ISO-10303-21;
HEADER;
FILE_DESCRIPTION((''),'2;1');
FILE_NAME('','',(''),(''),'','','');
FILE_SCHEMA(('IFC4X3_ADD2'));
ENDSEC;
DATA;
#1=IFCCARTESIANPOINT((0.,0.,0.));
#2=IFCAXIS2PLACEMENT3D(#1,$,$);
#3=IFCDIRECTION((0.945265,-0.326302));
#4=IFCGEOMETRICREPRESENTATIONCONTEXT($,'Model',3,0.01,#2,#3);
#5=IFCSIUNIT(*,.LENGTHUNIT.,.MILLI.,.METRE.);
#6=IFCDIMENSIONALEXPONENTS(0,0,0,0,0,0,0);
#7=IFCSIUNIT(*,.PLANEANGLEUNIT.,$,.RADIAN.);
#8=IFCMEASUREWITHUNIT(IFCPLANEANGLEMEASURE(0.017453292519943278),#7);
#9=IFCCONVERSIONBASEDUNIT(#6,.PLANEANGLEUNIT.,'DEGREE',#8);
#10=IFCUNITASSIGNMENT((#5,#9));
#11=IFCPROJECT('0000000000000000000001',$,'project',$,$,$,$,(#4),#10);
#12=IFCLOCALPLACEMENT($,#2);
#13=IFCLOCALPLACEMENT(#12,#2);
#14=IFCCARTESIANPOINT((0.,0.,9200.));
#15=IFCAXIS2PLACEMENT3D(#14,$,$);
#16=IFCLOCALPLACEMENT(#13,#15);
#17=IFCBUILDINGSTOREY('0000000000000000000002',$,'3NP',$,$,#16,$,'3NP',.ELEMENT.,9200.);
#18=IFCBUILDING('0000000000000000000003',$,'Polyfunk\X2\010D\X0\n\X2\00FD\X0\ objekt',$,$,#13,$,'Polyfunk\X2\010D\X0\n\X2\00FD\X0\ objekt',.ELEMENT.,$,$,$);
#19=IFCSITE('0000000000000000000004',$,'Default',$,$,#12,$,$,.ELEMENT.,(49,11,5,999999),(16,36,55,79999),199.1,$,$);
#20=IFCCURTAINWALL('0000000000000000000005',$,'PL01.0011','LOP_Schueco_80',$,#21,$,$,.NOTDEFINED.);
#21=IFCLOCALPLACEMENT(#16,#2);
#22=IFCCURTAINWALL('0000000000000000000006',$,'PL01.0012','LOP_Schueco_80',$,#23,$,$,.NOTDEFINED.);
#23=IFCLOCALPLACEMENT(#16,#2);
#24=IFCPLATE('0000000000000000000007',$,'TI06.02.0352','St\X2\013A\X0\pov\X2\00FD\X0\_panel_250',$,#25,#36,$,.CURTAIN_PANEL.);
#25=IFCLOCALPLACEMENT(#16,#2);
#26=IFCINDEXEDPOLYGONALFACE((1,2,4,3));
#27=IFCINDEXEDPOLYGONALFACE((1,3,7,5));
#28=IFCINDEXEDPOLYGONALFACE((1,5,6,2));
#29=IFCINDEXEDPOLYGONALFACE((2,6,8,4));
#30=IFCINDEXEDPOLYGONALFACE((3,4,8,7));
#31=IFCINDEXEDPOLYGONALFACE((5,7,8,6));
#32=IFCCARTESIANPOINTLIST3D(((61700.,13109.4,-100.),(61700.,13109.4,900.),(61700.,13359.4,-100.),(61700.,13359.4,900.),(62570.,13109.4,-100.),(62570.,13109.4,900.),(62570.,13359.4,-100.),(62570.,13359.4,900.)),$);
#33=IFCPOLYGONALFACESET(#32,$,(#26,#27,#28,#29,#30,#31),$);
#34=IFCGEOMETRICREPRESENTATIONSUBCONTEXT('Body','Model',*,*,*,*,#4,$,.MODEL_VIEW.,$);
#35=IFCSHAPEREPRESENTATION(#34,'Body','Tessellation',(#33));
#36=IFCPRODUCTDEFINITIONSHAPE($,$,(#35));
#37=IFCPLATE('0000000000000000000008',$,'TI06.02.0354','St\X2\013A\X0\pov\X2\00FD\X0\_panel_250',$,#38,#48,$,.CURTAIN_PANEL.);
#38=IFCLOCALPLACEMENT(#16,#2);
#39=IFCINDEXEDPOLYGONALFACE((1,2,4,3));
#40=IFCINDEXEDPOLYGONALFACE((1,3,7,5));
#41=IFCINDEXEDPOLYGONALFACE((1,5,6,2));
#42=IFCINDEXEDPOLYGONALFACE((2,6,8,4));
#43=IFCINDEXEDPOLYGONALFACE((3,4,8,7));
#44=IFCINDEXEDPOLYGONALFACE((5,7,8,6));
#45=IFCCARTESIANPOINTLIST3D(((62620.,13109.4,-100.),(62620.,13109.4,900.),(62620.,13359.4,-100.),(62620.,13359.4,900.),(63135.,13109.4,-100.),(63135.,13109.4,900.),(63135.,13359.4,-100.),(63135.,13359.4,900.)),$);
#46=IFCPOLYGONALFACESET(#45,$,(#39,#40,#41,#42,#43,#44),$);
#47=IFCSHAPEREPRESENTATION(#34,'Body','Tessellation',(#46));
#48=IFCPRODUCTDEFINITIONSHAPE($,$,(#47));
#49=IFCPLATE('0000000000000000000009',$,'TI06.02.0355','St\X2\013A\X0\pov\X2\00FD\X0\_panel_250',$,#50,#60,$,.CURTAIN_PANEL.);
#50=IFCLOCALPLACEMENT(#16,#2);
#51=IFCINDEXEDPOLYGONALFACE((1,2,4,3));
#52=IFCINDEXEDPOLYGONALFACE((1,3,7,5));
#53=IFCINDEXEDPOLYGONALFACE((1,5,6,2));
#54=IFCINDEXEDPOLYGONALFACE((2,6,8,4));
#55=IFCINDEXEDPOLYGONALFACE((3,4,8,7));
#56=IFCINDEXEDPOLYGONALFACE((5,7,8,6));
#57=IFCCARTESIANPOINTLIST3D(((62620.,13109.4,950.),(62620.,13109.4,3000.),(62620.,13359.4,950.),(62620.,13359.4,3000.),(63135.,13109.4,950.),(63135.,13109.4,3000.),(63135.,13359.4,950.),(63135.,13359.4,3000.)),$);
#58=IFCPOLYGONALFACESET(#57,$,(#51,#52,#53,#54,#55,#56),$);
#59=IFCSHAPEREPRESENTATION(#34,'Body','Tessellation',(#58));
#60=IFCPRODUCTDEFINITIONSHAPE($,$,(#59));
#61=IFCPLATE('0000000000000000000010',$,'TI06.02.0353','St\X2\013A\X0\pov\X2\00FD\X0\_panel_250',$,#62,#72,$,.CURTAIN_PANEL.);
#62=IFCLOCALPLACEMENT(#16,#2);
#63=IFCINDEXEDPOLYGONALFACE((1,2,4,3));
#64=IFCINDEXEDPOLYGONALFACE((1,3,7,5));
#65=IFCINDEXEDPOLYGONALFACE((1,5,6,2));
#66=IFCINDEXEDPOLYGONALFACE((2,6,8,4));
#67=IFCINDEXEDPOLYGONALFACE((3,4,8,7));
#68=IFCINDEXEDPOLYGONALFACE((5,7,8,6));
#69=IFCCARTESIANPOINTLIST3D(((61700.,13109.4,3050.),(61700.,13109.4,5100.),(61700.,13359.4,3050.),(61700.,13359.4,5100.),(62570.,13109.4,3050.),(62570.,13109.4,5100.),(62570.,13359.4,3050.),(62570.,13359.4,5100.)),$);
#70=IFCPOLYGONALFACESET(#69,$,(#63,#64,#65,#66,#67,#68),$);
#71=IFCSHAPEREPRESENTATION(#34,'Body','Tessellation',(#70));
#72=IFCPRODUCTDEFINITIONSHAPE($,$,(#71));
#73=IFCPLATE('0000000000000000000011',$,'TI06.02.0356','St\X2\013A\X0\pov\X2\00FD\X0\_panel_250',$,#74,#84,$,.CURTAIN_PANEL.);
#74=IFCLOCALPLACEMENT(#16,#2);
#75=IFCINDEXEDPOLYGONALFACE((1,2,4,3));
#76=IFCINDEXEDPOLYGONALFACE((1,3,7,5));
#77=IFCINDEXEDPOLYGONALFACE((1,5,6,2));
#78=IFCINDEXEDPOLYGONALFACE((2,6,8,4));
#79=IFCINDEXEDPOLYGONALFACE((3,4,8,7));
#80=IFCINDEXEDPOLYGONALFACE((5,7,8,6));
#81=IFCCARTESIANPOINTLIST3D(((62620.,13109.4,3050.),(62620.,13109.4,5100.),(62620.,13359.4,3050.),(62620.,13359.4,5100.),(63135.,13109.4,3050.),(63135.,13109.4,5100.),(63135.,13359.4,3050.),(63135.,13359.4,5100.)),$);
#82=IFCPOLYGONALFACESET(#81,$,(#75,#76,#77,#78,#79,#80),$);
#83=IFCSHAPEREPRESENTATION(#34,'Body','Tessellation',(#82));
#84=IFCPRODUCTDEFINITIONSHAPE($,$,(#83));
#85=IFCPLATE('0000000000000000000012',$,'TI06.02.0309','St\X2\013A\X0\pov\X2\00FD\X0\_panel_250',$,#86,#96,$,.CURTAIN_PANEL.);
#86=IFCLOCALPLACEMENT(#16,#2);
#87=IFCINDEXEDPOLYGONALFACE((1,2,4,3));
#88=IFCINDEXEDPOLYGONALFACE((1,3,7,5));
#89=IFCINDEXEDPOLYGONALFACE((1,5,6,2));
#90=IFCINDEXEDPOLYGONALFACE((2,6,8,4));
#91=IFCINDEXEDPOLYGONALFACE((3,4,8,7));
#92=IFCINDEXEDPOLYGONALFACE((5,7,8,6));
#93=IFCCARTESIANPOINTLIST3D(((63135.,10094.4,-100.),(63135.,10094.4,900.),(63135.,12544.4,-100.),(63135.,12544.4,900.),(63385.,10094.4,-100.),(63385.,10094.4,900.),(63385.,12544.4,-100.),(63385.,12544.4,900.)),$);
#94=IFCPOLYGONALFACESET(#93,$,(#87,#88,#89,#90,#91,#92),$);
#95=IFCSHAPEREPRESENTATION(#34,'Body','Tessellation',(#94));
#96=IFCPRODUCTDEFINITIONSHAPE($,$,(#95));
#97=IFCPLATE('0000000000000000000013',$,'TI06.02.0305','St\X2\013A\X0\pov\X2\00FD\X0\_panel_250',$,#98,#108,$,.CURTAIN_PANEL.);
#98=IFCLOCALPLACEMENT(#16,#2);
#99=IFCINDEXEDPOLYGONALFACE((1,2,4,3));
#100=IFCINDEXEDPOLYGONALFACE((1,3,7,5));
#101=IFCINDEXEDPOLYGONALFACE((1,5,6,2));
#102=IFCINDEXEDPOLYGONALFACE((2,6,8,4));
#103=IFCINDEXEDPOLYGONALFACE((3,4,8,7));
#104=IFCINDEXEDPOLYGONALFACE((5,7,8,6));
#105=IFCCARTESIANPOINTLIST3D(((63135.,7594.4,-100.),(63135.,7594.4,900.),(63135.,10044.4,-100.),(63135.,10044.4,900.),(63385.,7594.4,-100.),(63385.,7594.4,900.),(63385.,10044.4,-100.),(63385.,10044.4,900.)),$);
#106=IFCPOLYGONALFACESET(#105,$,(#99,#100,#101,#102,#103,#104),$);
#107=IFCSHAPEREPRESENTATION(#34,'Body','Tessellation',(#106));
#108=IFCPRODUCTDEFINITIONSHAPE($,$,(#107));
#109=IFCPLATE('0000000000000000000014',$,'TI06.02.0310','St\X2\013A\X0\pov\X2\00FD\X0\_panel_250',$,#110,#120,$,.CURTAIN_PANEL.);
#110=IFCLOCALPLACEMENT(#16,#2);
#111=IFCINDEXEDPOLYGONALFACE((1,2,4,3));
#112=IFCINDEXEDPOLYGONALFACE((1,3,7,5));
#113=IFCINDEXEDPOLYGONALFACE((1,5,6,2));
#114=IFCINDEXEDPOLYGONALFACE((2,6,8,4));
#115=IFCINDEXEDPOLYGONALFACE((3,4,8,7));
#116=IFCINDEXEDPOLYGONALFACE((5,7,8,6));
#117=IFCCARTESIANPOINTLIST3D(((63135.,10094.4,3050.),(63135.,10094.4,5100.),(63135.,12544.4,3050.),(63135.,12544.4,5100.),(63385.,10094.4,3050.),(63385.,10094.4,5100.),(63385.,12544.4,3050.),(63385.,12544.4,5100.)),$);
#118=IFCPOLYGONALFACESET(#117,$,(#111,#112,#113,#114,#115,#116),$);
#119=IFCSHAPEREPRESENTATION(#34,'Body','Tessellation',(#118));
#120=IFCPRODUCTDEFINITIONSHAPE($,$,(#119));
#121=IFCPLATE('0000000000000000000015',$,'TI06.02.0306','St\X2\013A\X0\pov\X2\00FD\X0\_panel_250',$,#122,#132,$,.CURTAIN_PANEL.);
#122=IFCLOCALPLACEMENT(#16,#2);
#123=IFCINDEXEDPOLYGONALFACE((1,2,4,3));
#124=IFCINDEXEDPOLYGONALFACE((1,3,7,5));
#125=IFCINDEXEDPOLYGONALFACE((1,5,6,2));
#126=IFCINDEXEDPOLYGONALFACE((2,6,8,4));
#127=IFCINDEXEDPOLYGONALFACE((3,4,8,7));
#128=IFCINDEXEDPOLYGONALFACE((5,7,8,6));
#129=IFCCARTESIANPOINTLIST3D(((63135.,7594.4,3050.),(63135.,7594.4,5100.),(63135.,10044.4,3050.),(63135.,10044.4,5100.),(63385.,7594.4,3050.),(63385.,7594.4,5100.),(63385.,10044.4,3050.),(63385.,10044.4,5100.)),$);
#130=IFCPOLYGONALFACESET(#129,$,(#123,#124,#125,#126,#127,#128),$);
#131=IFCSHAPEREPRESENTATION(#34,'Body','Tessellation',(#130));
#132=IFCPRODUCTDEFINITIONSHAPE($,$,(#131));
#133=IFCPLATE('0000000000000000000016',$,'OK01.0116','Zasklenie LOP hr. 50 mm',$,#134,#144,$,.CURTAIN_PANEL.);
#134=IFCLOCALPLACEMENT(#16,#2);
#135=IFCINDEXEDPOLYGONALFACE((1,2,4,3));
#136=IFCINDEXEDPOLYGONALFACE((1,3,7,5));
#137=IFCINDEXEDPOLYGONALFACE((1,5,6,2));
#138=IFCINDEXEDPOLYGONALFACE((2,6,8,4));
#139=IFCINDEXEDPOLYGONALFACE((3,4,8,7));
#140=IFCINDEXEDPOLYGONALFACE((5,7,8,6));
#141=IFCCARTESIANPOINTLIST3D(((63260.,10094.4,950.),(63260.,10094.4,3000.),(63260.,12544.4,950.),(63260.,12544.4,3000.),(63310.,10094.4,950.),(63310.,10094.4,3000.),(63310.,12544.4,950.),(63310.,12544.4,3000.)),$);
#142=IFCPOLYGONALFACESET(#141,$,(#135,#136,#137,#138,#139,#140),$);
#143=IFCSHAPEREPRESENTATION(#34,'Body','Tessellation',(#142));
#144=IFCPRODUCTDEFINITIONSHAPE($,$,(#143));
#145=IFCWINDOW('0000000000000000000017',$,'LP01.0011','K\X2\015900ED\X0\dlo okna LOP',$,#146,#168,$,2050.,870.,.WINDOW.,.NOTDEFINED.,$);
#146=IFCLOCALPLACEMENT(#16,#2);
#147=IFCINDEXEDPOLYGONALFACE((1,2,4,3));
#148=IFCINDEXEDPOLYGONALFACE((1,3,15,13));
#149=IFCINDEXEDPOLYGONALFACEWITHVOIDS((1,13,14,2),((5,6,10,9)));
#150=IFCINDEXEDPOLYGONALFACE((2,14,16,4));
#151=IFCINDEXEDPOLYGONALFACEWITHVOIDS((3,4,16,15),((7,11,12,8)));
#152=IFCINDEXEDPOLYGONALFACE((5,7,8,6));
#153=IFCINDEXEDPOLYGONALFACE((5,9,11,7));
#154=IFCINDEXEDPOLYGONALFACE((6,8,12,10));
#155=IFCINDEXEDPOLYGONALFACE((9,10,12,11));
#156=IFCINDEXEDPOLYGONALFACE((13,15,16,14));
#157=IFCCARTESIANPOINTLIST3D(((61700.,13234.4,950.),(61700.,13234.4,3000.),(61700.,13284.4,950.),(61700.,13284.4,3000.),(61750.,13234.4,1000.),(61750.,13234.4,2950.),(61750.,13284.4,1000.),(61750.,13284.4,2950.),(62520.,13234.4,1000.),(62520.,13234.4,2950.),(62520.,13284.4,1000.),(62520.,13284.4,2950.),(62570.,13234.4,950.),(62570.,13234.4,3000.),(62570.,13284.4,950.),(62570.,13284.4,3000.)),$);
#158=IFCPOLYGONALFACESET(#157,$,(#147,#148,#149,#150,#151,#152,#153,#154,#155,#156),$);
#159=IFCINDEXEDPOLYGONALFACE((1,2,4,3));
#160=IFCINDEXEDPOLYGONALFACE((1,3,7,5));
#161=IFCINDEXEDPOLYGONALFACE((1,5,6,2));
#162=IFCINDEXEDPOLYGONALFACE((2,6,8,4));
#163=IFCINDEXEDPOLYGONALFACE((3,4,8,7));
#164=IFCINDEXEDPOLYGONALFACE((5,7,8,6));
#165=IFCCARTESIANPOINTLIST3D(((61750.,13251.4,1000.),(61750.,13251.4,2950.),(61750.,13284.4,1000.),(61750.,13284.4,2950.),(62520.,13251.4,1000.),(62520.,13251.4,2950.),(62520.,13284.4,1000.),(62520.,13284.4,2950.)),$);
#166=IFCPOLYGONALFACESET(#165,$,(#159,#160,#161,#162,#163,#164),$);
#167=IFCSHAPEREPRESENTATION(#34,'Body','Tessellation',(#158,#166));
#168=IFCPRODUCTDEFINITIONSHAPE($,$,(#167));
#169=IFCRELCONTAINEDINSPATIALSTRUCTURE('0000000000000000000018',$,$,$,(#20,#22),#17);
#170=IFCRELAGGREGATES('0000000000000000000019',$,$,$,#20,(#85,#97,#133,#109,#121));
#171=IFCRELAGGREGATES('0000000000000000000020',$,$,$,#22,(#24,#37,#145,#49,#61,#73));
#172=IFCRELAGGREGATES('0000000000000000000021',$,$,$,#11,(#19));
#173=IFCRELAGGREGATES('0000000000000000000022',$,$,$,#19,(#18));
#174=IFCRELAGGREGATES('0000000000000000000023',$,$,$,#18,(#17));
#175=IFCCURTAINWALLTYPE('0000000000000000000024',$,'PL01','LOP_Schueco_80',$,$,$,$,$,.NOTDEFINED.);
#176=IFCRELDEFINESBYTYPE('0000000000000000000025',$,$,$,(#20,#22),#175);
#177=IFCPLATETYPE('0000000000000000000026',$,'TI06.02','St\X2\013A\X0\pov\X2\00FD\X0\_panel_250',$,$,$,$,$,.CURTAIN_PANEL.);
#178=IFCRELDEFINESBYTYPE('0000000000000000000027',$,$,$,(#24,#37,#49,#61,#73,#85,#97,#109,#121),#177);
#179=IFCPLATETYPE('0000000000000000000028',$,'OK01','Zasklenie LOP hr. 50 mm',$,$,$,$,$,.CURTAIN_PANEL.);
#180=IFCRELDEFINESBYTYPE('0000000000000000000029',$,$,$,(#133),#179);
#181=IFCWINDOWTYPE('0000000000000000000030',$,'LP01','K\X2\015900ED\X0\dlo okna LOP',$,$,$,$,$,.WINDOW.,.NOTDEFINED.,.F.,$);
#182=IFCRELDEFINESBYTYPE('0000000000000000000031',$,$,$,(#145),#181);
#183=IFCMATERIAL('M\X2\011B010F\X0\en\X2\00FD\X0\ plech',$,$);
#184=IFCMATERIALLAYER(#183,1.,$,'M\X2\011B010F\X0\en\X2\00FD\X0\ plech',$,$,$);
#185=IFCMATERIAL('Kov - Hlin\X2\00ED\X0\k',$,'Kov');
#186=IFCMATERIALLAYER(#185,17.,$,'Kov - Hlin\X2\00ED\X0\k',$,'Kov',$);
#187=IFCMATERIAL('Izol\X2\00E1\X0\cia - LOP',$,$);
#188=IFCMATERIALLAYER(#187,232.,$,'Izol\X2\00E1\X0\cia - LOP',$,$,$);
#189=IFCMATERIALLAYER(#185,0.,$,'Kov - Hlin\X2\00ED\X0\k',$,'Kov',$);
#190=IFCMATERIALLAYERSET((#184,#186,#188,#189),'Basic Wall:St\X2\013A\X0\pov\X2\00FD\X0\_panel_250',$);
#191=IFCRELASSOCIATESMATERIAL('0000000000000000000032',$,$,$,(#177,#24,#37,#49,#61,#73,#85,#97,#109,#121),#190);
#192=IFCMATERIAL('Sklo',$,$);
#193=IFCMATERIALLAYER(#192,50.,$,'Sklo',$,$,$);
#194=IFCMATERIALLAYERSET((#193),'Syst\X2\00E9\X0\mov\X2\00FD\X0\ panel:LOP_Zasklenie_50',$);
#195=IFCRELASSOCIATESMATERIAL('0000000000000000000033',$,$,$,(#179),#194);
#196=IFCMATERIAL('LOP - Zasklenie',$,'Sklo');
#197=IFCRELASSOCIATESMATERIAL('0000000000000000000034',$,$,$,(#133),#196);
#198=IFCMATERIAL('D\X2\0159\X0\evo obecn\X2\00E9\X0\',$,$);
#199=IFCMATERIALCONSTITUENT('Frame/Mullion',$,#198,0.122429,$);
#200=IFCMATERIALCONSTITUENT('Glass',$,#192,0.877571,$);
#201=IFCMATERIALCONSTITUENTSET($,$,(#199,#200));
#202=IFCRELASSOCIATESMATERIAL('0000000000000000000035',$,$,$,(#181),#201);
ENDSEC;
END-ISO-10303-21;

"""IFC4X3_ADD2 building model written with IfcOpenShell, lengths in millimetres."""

from ifc_helpers import new_model, entity, si_unit, converted_unit, direction, frame, frame_2d, origin, origin_2d_with_axis, place, context, subcontext, project, spatial, polyline, rectangle, outline, extrude, source, transform, mapped, material, layer, layer_set, layer_usage, constituent, constituent_set, type_object, type_shapes, element, aggregate, save


model = new_model("IFC4X3_ADD2")

# Units and contexts
model_context = context("Model", 3, precision=0.01, world=origin(), true_north=direction((0.945265, -0.326302)))
body_context = subcontext(model_context, "Body", "Model", "MODEL_VIEW")
ifc_project = project(units=[si_unit("LENGTHUNIT", "METRE", prefix="MILLI"), converted_unit("PLANEANGLEUNIT", "DEGREE", entity("IfcPlaneAngleMeasure", 0.017453292519943278), si_unit("PLANEANGLEUNIT", "RADIAN"), dimensions=[0, 0, 0, 0, 0, 0, 0])], contexts=[model_context])

# Site, building, storey
site_placement = place(None, origin())
site = spatial("IfcSite", under=ifc_project, at=site_placement, Name="Default", CompositionType="ELEMENT", RefLatitude=(49, 11, 5, 999999), RefLongitude=(16, 36, 55, 79999), RefElevation=199.1)
building_placement = place(site_placement, origin())
building = spatial("IfcBuilding", under=site, at=building_placement, Name="Polyfunkčný objekt", LongName="Polyfunkčný objekt", CompositionType="ELEMENT")
storey_placement = place(building_placement, frame((0.0, 0.0, 9200.0)))
storey = spatial("IfcBuildingStorey", under=building, at=storey_placement, Name="3NP", LongName="3NP", CompositionType="ELEMENT", Elevation=9200.0)

# Curtain walls
curtain_wall_type = type_object("IfcCurtainWallType", Name="PL01", Description="LOP_Schueco_80", PredefinedType="NOTDEFINED")
curtain_wall_1_placement = place(storey_placement, frame((0.0, 0.0, -9200.0)))
curtain_wall_1 = element("IfcCurtainWall", 1, at=curtain_wall_1_placement, inside=storey, type_object=curtain_wall_type, Name="PL01.0011", Description="LOP_Schueco_80", PredefinedType="NOTDEFINED")
curtain_wall_2_placement = place(storey_placement, frame((0.0, 0.0, -9200.0)))
curtain_wall_2 = element("IfcCurtainWall", 2, at=curtain_wall_2_placement, inside=storey, type_object=curtain_wall_type, Name="PL01.0012", Description="LOP_Schueco_80", PredefinedType="NOTDEFINED")

# Plates
ifc_material_1 = material(Name="Měďený plech")
ifc_layer_1 = layer(ifc_material_1, 1.0, Name="Měďený plech")
ifc_material_2 = material(Name="Kov - Hliník", Category="Kov")
ifc_layer_2 = layer(ifc_material_2, 17.0, Name="Kov - Hliník", Category="Kov")
ifc_material_3 = material(Name="Izolácia - LOP")
ifc_layer_3 = layer(ifc_material_3, 232.0, Name="Izolácia - LOP")
ifc_layer_4 = layer(ifc_material_2, 0.0, Name="Kov - Hliník", Category="Kov")
ifc_layer_set_1 = layer_set([ifc_layer_1, ifc_layer_2, ifc_layer_3, ifc_layer_4], Name="Basic Wall:Stĺpový_panel_250")
ifc_layer_usage_1 = layer_usage(ifc_layer_set_1, "AXIS2", "NEGATIVE", 125.0)
plate_type_1 = type_object("IfcPlateType", Name="TI06.02", Description="Stĺpový_panel_250", PredefinedType="CURTAIN_PANEL", material=ifc_layer_set_1)
plate_1_placement = place(storey_placement, frame((61700.0, 13234.4, -100.0)))
plate_1 = element("IfcPlate", 3, at=plate_1_placement, type_object=plate_type_1, material=ifc_layer_usage_1, Name="TI06.02.0352", Description="Stĺpový_panel_250", PredefinedType="CURTAIN_PANEL", context=body_context, shape_type="SweptSolid", body=[
    extrude(rectangle(XDim=250.0, YDim=870.0, at=frame_2d((0.0, 0.0), x_axis=(1.0, 0.0))), frame((435.0, 0.0, 0.0), z_axis=(0.0, 0.0, 1.0), x_axis=(0.0, 1.0, 0.0)), (0.0, 0.0, 1.0), 1000.0),
])
ifc_layer_usage_2 = layer_usage(ifc_layer_set_1, "AXIS2", "NEGATIVE", 125.0)
plate_2_placement = place(storey_placement, frame((62620.0, 13234.4, -100.0)))
plate_2 = element("IfcPlate", 4, at=plate_2_placement, type_object=plate_type_1, material=ifc_layer_usage_2, Name="TI06.02.0354", Description="Stĺpový_panel_250", PredefinedType="CURTAIN_PANEL", context=body_context, shape_type="SweptSolid", body=[
    extrude(rectangle(XDim=250.0, YDim=515.0, at=frame_2d((0.0, 0.0), x_axis=(1.0, 0.0))), frame((257.5, 0.0, 0.0), z_axis=(0.0, 0.0, 1.0), x_axis=(0.0, 1.0, 0.0)), (0.0, 0.0, 1.0), 1000.0),
])
ifc_layer_usage_3 = layer_usage(ifc_layer_set_1, "AXIS2", "NEGATIVE", 125.0)
plate_3_placement = place(storey_placement, frame((62620.0, 13234.4, 950.0)))
plate_3 = element("IfcPlate", 5, at=plate_3_placement, type_object=plate_type_1, material=ifc_layer_usage_3, Name="TI06.02.0355", Description="Stĺpový_panel_250", PredefinedType="CURTAIN_PANEL", context=body_context, shape_type="SweptSolid", body=[
    extrude(rectangle(XDim=250.0, YDim=515.0, at=frame_2d((0.0, 0.0), x_axis=(1.0, 0.0))), frame((257.5, 0.0, 0.0), z_axis=(0.0, 0.0, 1.0), x_axis=(0.0, 1.0, 0.0)), (0.0, 0.0, 1.0), 2050.0),
])
ifc_layer_usage_4 = layer_usage(ifc_layer_set_1, "AXIS2", "NEGATIVE", 125.0)
plate_4_placement = place(storey_placement, frame((61700.0, 13234.4, 3050.0)))
plate_4 = element("IfcPlate", 6, at=plate_4_placement, type_object=plate_type_1, material=ifc_layer_usage_4, Name="TI06.02.0353", Description="Stĺpový_panel_250", PredefinedType="CURTAIN_PANEL", context=body_context, shape_type="SweptSolid", body=[
    extrude(rectangle(XDim=250.0, YDim=870.0, at=frame_2d((0.0, 0.0), x_axis=(1.0, 0.0))), frame((435.0, 0.0, 0.0), z_axis=(0.0, 0.0, 1.0), x_axis=(0.0, 1.0, 0.0)), (0.0, 0.0, 1.0), 2050.0),
])
ifc_layer_usage_5 = layer_usage(ifc_layer_set_1, "AXIS2", "NEGATIVE", 125.0)
plate_5_placement = place(storey_placement, frame((62620.0, 13234.4, 3050.0)))
plate_5 = element("IfcPlate", 7, at=plate_5_placement, type_object=plate_type_1, material=ifc_layer_usage_5, Name="TI06.02.0356", Description="Stĺpový_panel_250", PredefinedType="CURTAIN_PANEL", context=body_context, shape_type="SweptSolid", body=[
    extrude(rectangle(XDim=250.0, YDim=515.0, at=frame_2d((0.0, 0.0), x_axis=(1.0, 0.0))), frame((257.5, 0.0, 0.0), z_axis=(0.0, 0.0, 1.0), x_axis=(0.0, 1.0, 0.0)), (0.0, 0.0, 1.0), 2050.0),
])
ifc_layer_usage_6 = layer_usage(ifc_layer_set_1, "AXIS2", "NEGATIVE", 125.0)
plate_6_placement = place(storey_placement, frame((63260.0, 12544.4, -100.0), z_axis=(0.0, 0.0, 1.0), x_axis=(0.0, -1.0, 0.0)))
plate_6 = element("IfcPlate", 8, at=plate_6_placement, type_object=plate_type_1, material=ifc_layer_usage_6, Name="TI06.02.0309", Description="Stĺpový_panel_250", PredefinedType="CURTAIN_PANEL", context=body_context, shape_type="SweptSolid", body=[
    extrude(rectangle(XDim=250.0, YDim=2450.0, at=frame_2d((0.0, 0.0), x_axis=(1.0, 0.0))), frame((1225.0, 0.0, 0.0), z_axis=(0.0, 0.0, 1.0), x_axis=(0.0, 1.0, 0.0)), (0.0, 0.0, 1.0), 1000.0),
])
ifc_layer_usage_7 = layer_usage(ifc_layer_set_1, "AXIS2", "NEGATIVE", 125.0)
plate_7_placement = place(storey_placement, frame((63260.0, 10044.4, -100.0), z_axis=(0.0, 0.0, 1.0), x_axis=(0.0, -1.0, 0.0)))
plate_7 = element("IfcPlate", 9, at=plate_7_placement, type_object=plate_type_1, material=ifc_layer_usage_7, Name="TI06.02.0305", Description="Stĺpový_panel_250", PredefinedType="CURTAIN_PANEL", context=body_context, shape_type="SweptSolid", body=[
    extrude(rectangle(XDim=250.0, YDim=2450.0, at=origin_2d_with_axis()), frame((1225.0, 0.0, 0.0), z_axis=(0.0, 0.0, 1.0), x_axis=(0.0, 1.0, 0.0)), (0.0, 0.0, 1.0), 1000.0),
])
ifc_layer_usage_8 = layer_usage(ifc_layer_set_1, "AXIS2", "NEGATIVE", 125.0)
plate_8_placement = place(storey_placement, frame((63260.0, 12544.4, 3050.0), z_axis=(0.0, 0.0, 1.0), x_axis=(0.0, -1.0, 0.0)))
plate_8 = element("IfcPlate", 10, at=plate_8_placement, type_object=plate_type_1, material=ifc_layer_usage_8, Name="TI06.02.0310", Description="Stĺpový_panel_250", PredefinedType="CURTAIN_PANEL", context=body_context, shape_type="SweptSolid", body=[
    extrude(rectangle(XDim=250.0, YDim=2450.0, at=frame_2d((0.0, 0.0), x_axis=(1.0, 0.0))), frame((1225.0, 0.0, 0.0), z_axis=(0.0, 0.0, 1.0), x_axis=(0.0, 1.0, 0.0)), (0.0, 0.0, 1.0), 2050.0),
])
ifc_layer_usage_9 = layer_usage(ifc_layer_set_1, "AXIS2", "NEGATIVE", 125.0)
plate_9_placement = place(storey_placement, frame((63260.0, 10044.4, 3050.0), z_axis=(0.0, 0.0, 1.0), x_axis=(0.0, -1.0, 0.0)))
plate_9 = element("IfcPlate", 11, at=plate_9_placement, type_object=plate_type_1, material=ifc_layer_usage_9, Name="TI06.02.0306", Description="Stĺpový_panel_250", PredefinedType="CURTAIN_PANEL", context=body_context, shape_type="SweptSolid", body=[
    extrude(rectangle(XDim=250.0, YDim=2450.0, at=frame_2d((0.0, 0.0), x_axis=(1.0, 0.0))), frame((1225.0, 0.0, 0.0), z_axis=(0.0, 0.0, 1.0), x_axis=(0.0, 1.0, 0.0)), (0.0, 0.0, 1.0), 2050.0),
])
ifc_material_4 = material(Name="LOP - Zasklenie", Category="Sklo")
ifc_material_5 = material(Name="Sklo")
ifc_layer_5 = layer(ifc_material_5, 50.0, Name="Sklo")
ifc_layer_set_2 = layer_set([ifc_layer_5], Name="Systémový panel:LOP_Zasklenie_50")
plate_type_2 = type_object("IfcPlateType", Name="OK01", Description="Zasklenie LOP hr. 50 mm", PredefinedType="CURTAIN_PANEL", material=ifc_layer_set_2)
shared_shape_1 = source(origin(), body_context, "Body", "SweptSolid", [
    extrude(rectangle(XDim=50.0, YDim=2450.0, at=origin_2d_with_axis()), frame((0.0, 25.0, 0.0), z_axis=(0.0, 0.0, 1.0), x_axis=(0.0, 1.0, 0.0)), (0.0, 0.0, 1.0), 2050.0),
])
type_shapes(plate_type_2, [shared_shape_1])
plate_10_placement = place(curtain_wall_1_placement, frame((63260.0, 11319.4, 10150.0), z_axis=(0.0, 0.0, 1.0), x_axis=(0.0, -1.0, 0.0)))
plate_10 = element("IfcPlate", 12, at=plate_10_placement, type_object=plate_type_2, material=ifc_material_4, Name="OK01.0116", Description="Zasklenie LOP hr. 50 mm", PredefinedType="CURTAIN_PANEL", context=body_context, shape_type="MappedRepresentation", body=[
    mapped(shared_shape_1, transform((0.0, 0.0, 0.0), scale=1.0)),
])
aggregate(curtain_wall_1, [plate_6, plate_7, plate_10, plate_8, plate_9])

# Window
ifc_material_6 = material(Name="Dřevo obecné")
ifc_constituent_1 = constituent(ifc_material_6, Name="Frame/Mullion", fraction=0.122429)
ifc_constituent_2 = constituent(ifc_material_5, Name="Glass", fraction=0.877571)
ifc_constituent_set = constituent_set(constituents=[ifc_constituent_1, ifc_constituent_2])
window_type = type_object("IfcWindowType", Name="LP01", Description="Křídlo okna LOP", ParameterTakesPrecedence=False, PartitioningType="NOTDEFINED", PredefinedType="WINDOW", material=ifc_constituent_set)
shared_shape_2 = source(origin(), body_context, "Body", "SweptSolid", [
    extrude(outline(polyline([(-1025.0, -435.0), (1025.0, -435.0), (1025.0, 435.0), (-1025.0, 435.0), (-1025.0, -435.0)]), holes=[polyline([(-975.0, -385.0), (-975.0, 385.0), (975.0, 385.0), (975.0, -385.0), (-975.0, -385.0)])]), frame((0.0, 0.0, 1025.0), z_axis=(0.0, 1.0, 0.0), x_axis=(0.0, 0.0, -1.0)), (0.0, 0.0, 1.0), 50.0),
    extrude(rectangle(XDim=33.0, YDim=770.0, at=origin_2d_with_axis()), frame((0.0, 33.5, 50.0), z_axis=(0.0, 0.0, 1.0), x_axis=(0.0, -1.0, 0.0)), (0.0, 0.0, 1.0), 1950.0),
])
type_shapes(window_type, [shared_shape_2])
window_placement = place(curtain_wall_2_placement, frame((62135.0, 13234.4, 10150.0)))
window = element("IfcWindow", 13, at=window_placement, type_object=window_type, Name="LP01.0011", Description="Křídlo okna LOP", OverallHeight=2050.0, OverallWidth=870.0, PartitioningType="NOTDEFINED", PredefinedType="WINDOW", context=body_context, shape_type="MappedRepresentation", body=[
    mapped(shared_shape_2, transform((0.0, 0.0, 0.0), scale=1.0)),
])
aggregate(curtain_wall_2, [plate_1, plate_2, window, plate_3, plate_4, plate_5])

save(model, "model.ifc")
